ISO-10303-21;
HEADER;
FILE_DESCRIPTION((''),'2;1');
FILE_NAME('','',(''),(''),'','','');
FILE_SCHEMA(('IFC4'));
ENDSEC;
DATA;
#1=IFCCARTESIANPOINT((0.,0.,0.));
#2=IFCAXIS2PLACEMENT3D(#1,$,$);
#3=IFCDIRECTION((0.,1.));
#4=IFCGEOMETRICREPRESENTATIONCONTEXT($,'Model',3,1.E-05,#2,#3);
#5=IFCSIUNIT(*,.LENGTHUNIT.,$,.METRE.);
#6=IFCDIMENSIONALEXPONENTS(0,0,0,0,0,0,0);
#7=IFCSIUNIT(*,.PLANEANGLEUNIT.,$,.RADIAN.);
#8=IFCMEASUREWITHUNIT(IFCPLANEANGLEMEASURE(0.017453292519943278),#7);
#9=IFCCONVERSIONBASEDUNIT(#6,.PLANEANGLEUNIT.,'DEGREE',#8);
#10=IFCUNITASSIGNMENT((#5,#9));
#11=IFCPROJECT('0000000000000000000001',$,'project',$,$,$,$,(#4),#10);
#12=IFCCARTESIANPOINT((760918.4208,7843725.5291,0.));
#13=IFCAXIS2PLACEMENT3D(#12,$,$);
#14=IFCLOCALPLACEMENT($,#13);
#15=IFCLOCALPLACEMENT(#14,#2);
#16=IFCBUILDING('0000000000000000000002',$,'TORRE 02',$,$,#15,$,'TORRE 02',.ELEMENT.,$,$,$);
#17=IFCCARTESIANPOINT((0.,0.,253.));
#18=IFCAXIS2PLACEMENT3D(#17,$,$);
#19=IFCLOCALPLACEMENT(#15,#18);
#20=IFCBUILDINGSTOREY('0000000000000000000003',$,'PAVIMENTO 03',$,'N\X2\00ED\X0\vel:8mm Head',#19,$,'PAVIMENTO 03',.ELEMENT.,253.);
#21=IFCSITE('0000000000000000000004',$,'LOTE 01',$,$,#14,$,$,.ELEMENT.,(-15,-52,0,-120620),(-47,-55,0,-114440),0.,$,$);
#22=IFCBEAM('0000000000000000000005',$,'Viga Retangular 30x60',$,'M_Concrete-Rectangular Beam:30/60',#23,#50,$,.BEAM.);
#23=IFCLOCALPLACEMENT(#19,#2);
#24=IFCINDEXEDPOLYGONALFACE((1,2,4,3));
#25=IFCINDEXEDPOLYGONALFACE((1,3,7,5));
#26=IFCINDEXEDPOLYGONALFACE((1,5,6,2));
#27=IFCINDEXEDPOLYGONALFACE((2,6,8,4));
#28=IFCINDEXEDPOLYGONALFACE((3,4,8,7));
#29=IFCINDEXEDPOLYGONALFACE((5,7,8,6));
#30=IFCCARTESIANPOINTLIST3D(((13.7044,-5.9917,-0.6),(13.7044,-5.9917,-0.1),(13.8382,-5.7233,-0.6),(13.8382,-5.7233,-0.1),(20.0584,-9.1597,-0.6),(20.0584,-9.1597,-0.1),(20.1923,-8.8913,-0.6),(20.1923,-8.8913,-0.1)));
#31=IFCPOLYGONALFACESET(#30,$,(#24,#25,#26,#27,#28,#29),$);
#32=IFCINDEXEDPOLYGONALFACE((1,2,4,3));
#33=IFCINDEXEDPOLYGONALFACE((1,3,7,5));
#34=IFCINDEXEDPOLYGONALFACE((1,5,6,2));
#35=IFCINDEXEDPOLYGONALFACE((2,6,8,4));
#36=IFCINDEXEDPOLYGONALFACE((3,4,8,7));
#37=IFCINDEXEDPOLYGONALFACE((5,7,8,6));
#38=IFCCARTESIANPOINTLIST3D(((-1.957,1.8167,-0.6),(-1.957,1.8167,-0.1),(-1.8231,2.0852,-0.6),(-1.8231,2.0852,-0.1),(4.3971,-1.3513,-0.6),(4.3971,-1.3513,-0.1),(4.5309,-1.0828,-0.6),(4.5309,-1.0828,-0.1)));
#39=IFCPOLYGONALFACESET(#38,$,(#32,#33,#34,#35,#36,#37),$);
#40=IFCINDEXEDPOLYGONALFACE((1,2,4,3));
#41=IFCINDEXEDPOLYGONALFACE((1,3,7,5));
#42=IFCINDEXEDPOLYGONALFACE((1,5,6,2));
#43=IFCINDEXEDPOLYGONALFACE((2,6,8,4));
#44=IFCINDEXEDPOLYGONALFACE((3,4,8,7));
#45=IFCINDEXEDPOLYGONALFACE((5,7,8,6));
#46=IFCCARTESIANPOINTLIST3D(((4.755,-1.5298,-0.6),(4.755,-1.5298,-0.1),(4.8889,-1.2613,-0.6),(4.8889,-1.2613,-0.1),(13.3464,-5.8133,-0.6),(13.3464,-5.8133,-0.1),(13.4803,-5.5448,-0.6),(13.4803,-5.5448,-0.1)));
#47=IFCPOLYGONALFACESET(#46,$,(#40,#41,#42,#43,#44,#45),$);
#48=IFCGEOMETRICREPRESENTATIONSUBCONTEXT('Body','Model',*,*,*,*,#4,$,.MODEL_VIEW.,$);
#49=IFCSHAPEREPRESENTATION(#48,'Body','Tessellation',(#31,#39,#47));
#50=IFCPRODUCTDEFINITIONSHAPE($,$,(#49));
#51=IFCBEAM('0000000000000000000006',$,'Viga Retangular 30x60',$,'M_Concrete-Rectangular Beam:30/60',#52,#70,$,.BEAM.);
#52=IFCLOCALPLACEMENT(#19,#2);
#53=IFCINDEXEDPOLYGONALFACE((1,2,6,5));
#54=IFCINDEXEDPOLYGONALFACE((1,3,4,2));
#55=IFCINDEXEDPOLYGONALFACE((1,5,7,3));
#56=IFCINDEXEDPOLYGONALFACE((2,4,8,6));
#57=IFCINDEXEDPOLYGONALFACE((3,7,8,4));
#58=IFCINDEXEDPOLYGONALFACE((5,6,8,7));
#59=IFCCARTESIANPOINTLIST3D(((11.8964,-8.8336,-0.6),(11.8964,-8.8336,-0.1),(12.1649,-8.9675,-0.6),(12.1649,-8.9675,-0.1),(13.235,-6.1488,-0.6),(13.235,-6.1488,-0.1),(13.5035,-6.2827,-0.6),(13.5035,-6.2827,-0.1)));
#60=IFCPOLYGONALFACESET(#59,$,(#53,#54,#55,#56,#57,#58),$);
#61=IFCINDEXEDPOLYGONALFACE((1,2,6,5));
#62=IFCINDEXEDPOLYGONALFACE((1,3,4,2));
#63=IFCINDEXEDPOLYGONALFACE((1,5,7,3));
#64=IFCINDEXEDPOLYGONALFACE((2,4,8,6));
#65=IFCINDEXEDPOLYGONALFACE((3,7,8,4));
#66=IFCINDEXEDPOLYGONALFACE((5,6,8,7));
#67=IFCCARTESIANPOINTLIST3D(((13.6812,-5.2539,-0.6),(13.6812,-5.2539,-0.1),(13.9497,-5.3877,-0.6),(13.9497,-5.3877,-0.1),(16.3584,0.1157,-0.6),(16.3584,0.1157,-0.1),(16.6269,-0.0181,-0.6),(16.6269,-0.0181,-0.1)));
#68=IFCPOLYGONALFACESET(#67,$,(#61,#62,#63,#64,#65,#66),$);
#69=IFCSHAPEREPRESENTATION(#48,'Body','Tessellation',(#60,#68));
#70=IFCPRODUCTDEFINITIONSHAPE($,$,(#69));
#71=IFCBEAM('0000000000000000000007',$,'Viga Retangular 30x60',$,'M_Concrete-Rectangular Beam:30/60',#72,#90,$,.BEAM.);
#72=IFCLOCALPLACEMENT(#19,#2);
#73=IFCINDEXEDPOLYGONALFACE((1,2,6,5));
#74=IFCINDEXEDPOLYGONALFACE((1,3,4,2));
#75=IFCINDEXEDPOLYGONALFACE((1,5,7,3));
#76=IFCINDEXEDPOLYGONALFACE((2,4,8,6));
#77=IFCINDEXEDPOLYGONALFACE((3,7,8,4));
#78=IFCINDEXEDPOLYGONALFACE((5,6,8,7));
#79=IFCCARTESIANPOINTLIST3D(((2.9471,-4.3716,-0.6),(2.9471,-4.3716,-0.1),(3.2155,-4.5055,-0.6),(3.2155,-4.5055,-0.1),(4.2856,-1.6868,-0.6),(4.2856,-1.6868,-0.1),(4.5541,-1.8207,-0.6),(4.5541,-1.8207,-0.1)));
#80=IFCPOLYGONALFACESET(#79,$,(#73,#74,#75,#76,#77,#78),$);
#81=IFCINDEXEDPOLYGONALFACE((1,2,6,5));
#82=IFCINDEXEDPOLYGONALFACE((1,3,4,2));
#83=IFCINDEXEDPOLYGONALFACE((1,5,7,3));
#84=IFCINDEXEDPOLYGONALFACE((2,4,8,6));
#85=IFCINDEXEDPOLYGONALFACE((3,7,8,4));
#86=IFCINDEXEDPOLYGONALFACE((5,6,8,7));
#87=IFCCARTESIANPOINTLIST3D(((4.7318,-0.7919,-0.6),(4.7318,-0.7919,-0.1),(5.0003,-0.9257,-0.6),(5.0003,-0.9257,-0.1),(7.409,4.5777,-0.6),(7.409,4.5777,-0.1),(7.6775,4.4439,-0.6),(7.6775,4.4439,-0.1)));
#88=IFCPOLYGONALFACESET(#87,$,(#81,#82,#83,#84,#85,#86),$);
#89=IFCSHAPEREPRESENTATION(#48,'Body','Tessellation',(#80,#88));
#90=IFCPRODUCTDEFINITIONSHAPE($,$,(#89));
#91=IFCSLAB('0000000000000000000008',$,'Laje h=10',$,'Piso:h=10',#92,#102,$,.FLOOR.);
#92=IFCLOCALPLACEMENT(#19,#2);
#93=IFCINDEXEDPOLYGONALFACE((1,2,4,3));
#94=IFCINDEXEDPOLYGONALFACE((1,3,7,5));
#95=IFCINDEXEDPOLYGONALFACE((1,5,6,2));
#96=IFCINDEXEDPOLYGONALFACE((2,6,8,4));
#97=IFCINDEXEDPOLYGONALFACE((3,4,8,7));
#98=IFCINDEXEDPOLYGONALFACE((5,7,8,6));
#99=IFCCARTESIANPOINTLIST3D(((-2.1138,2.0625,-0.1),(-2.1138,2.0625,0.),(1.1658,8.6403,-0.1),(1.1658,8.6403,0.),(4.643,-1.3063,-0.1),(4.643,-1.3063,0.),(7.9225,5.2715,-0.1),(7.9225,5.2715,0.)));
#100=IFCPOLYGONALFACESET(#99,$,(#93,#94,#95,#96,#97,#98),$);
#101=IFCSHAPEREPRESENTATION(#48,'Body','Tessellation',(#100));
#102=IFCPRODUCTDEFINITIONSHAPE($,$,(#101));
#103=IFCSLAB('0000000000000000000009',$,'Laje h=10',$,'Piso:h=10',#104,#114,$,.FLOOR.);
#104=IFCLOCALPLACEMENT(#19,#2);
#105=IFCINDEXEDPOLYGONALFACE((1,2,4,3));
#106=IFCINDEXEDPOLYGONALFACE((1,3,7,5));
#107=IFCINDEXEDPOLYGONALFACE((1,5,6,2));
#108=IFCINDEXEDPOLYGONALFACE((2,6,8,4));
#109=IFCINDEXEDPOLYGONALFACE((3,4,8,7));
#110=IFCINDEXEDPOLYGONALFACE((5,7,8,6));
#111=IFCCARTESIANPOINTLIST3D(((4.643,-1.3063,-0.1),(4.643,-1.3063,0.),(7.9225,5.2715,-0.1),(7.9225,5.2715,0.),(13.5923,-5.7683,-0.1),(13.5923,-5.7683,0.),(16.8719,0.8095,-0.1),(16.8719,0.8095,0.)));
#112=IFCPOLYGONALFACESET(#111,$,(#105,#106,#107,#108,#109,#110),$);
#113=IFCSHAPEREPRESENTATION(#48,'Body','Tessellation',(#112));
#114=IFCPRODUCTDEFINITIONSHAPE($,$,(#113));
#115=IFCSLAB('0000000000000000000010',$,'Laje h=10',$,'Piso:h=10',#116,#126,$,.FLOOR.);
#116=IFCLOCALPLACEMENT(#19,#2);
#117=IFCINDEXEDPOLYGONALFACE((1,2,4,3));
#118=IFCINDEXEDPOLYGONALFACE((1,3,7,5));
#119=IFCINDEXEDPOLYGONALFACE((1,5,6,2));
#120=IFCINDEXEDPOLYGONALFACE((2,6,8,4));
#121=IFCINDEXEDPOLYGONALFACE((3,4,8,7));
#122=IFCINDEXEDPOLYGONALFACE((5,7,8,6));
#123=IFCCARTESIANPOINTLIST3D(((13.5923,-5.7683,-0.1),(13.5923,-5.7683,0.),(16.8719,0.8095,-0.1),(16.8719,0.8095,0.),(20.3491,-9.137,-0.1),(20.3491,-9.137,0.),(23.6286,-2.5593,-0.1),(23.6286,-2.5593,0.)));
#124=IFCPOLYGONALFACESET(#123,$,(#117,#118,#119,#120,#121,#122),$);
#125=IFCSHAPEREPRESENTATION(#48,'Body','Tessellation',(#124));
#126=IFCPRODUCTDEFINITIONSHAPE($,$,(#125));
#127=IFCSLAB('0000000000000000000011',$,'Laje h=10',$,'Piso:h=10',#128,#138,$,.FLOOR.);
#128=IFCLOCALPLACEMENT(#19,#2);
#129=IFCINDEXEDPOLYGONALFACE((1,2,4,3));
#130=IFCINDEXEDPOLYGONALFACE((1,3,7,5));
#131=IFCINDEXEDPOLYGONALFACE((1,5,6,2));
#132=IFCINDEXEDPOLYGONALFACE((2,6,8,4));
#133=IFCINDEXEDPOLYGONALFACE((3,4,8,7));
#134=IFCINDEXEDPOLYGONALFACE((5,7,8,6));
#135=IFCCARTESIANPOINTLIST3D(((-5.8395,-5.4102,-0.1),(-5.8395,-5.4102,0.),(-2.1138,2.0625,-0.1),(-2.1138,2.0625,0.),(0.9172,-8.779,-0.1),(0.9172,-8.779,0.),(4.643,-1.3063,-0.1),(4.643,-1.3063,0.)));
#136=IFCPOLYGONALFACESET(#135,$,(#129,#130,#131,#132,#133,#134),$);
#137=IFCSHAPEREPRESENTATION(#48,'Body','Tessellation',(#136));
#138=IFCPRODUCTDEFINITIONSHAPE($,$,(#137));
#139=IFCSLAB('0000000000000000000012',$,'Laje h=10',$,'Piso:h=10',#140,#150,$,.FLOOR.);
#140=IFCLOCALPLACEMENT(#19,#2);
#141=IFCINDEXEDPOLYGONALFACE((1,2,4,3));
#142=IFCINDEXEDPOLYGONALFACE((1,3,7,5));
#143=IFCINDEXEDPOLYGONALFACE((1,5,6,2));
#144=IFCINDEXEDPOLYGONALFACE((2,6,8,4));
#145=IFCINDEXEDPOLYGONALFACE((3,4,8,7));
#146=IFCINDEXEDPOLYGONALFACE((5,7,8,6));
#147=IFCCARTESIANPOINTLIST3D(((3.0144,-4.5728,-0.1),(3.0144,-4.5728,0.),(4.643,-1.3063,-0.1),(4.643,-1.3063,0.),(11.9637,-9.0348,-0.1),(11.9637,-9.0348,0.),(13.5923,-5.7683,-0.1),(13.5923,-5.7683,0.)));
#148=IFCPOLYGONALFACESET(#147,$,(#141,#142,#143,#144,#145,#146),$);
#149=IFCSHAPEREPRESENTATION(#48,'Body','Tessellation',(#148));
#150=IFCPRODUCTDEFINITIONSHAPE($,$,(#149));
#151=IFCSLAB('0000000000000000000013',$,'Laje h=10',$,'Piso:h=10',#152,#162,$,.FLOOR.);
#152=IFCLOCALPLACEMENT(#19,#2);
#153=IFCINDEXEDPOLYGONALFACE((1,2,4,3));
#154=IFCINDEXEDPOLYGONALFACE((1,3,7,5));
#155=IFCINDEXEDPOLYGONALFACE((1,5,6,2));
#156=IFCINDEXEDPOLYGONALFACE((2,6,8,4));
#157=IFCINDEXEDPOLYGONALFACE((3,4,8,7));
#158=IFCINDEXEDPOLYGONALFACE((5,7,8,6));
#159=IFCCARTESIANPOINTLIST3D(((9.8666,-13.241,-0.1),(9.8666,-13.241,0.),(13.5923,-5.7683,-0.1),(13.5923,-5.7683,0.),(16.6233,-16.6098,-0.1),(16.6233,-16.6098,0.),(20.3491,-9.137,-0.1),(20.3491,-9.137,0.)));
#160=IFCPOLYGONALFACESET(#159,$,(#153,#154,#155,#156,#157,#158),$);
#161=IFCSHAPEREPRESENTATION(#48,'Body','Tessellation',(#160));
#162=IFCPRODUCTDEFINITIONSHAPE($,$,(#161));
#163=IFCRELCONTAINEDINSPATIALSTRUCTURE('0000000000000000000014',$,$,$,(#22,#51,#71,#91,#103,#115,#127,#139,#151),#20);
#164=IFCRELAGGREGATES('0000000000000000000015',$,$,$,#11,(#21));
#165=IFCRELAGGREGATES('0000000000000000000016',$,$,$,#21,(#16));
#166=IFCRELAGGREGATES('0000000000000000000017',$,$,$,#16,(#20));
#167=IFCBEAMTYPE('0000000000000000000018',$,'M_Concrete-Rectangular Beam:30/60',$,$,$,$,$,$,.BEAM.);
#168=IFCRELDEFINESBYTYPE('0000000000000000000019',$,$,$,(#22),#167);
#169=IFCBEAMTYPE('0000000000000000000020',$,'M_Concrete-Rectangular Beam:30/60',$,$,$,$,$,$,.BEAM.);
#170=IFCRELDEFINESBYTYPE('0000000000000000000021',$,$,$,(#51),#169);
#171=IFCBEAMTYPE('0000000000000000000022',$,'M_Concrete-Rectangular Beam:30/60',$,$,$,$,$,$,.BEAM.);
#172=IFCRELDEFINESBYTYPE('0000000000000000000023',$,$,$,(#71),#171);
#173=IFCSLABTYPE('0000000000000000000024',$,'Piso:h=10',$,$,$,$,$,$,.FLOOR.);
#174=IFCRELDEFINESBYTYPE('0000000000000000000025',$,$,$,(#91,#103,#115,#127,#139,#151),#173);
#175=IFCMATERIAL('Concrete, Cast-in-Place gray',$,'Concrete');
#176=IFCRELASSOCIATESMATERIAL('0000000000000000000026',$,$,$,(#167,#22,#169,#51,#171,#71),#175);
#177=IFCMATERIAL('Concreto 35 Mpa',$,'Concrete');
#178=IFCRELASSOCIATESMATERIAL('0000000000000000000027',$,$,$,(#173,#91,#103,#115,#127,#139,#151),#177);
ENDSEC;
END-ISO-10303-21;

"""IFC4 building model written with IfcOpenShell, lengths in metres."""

from ifc_helpers import new_model, entity, si_unit, converted_unit, direction, frame, origin, place, context, subcontext, project, spatial, indexed_curve, outline, extrude, source, transform, mapped, material, type_object, type_shapes, element, save


model = new_model("IFC4")

# Units and contexts
model_context = context("Model", 3, precision=1e-05, world=origin(), true_north=direction((0.0, 1.0)))
body_context = subcontext(model_context, "Body", "Model", "MODEL_VIEW")
ifc_project = project(units=[si_unit("LENGTHUNIT", "METRE"), converted_unit("PLANEANGLEUNIT", "DEGREE", entity("IfcPlaneAngleMeasure", 0.017453292519943278), si_unit("PLANEANGLEUNIT", "RADIAN"), dimensions=[0, 0, 0, 0, 0, 0, 0])], contexts=[model_context])

# Site, building, storey
site_placement = place(None, frame((760918.4208, 7843725.5291, 0.0)))
site = spatial("IfcSite", under=ifc_project, at=site_placement, Name="LOTE 01", CompositionType="ELEMENT", RefLatitude=(-15, -52, 0, -120620), RefLongitude=(-47, -55, 0, -114440), RefElevation=0.0)
building_placement = place(site_placement, origin())
building = spatial("IfcBuilding", under=site, at=building_placement, Name="TORRE 02", LongName="TORRE 02", CompositionType="ELEMENT")
storey_placement = place(building_placement, frame((0.0, 0.0, 253.0)))
storey = spatial("IfcBuildingStorey", under=building, at=storey_placement, Name="PAVIMENTO 03", ObjectType="Nível:8mm Head", LongName="PAVIMENTO 03", CompositionType="ELEMENT", Elevation=253.0)

# Shared definitions
ifc_material_1 = material(Name="Concrete, Cast-in-Place gray", Category="Concrete")

# Beams
beam_type_1 = type_object("IfcBeamType", Name="M_Concrete-Rectangular Beam:30/60", PredefinedType="BEAM", material=ifc_material_1)
shared_shape_1 = source(origin(), body_context, "Body", "SweptSolid", [
    extrude(outline(indexed_curve([(-0.25, -0.15), (0.25, -0.15), (0.25, 0.15), (-0.25, 0.15), (-0.25, -0.15)], self_intersect=False)), frame((13.7713, -5.8575, 252.65), z_axis=(0.894934, -0.446198, 0.0), x_axis=(0.0, 0.0, -1.0)), (0.0, 0.0, 1.0), 7.1),
    extrude(outline(indexed_curve([(-0.25, -0.15), (0.25, -0.15), (0.25, 0.15), (-0.25, 0.15), (-0.25, -0.15)], self_intersect=False)), frame((-1.89, 1.951, 252.65), z_axis=(0.894934, -0.446198, 0.0), x_axis=(0.0, 0.0, -1.0)), (0.0, 0.0, 1.0), 7.1),
    extrude(outline(indexed_curve([(-0.25, -0.15), (0.25, -0.15), (0.25, 0.15), (-0.25, 0.15), (-0.25, -0.15)], self_intersect=False)), frame((4.822, -1.3955, 252.65), z_axis=(0.894934, -0.446198, 0.0), x_axis=(0.0, 0.0, -1.0)), (0.0, 0.0, 1.0), 9.6),
])
type_shapes(beam_type_1, [shared_shape_1])
beam_1_placement = place(storey_placement, frame((0.0, 0.0, -253.0)))
element("IfcBeam", 1, at=beam_1_placement, inside=storey, type_object=beam_type_1, material=ifc_material_1, Name="Viga Retangular 30x60", ObjectType="M_Concrete-Rectangular Beam:30/60", PredefinedType="BEAM", context=body_context, shape_type="MappedRepresentation", body=[
    mapped(shared_shape_1, transform((0.0, 0.0, 0.0), scale=1.0)),
])
beam_type_2 = type_object("IfcBeamType", Name="M_Concrete-Rectangular Beam:30/60", PredefinedType="BEAM", material=ifc_material_1)
shared_shape_2 = source(origin(), body_context, "Body", "SweptSolid", [
    extrude(outline(indexed_curve([(-0.25, -0.15), (0.25, -0.15), (0.25, 0.15), (-0.25, 0.15), (-0.25, -0.15)], self_intersect=False)), frame((12.0306, -8.9005, 252.65), z_axis=(0.446198, 0.894934, 0.0), x_axis=(0.0, 0.0, 1.0)), (0.0, 0.0, 1.0), 3.0),
    extrude(outline(indexed_curve([(-0.25, -0.15), (0.25, -0.15), (0.25, 0.15), (-0.25, 0.15), (-0.25, -0.15)], self_intersect=False)), frame((13.8154, -5.3208, 252.65), z_axis=(0.446198, 0.894934, 0.0), x_axis=(0.0, 0.0, 1.0)), (0.0, 0.0, 1.0), 6.0),
])
type_shapes(beam_type_2, [shared_shape_2])
beam_2_placement = place(storey_placement, frame((0.0, 0.0, -253.0)))
element("IfcBeam", 2, at=beam_2_placement, inside=storey, type_object=beam_type_2, material=ifc_material_1, Name="Viga Retangular 30x60", ObjectType="M_Concrete-Rectangular Beam:30/60", PredefinedType="BEAM", context=body_context, shape_type="MappedRepresentation", body=[
    mapped(shared_shape_2, transform((0.0, 0.0, 0.0), scale=1.0)),
])
beam_type_3 = type_object("IfcBeamType", Name="M_Concrete-Rectangular Beam:30/60", PredefinedType="BEAM", material=ifc_material_1)
shared_shape_3 = source(origin(), body_context, "Body", "SweptSolid", [
    extrude(outline(indexed_curve([(-0.25, -0.15), (0.25, -0.15), (0.25, 0.15), (-0.25, 0.15), (-0.25, -0.15)], self_intersect=False)), frame((3.0813, -4.4385, 252.65), z_axis=(0.446198, 0.894934, 0.0), x_axis=(0.0, 0.0, 1.0)), (0.0, 0.0, 1.0), 3.0),
    extrude(outline(indexed_curve([(-0.25, -0.15), (0.25, -0.15), (0.25, 0.15), (-0.25, 0.15), (-0.25, -0.15)], self_intersect=False)), frame((4.8661, -0.8588, 252.65), z_axis=(0.446198, 0.894934, 0.0), x_axis=(0.0, 0.0, 1.0)), (0.0, 0.0, 1.0), 6.0),
])
type_shapes(beam_type_3, [shared_shape_3])
beam_3_placement = place(storey_placement, frame((0.0, 0.0, -253.0)))
element("IfcBeam", 3, at=beam_3_placement, inside=storey, type_object=beam_type_3, material=ifc_material_1, Name="Viga Retangular 30x60", ObjectType="M_Concrete-Rectangular Beam:30/60", PredefinedType="BEAM", context=body_context, shape_type="MappedRepresentation", body=[
    mapped(shared_shape_3, transform((0.0, 0.0, 0.0), scale=1.0)),
])

# Slabs
ifc_material_2 = material(Name="Concreto 35 Mpa", Category="Concrete")
slab_type = type_object("IfcSlabType", Name="Piso:h=10", PredefinedType="FLOOR", material=ifc_material_2)
slab_1_placement = place(storey_placement, origin())
element("IfcSlab", 4, at=slab_1_placement, inside=storey, type_object=slab_type, material=ifc_material_2, Name="Laje h=10", ObjectType="Piso:h=10", PredefinedType="FLOOR", context=body_context, shape_type="SweptSolid", body=[
    extrude(outline(indexed_curve([(-3.675, -3.775), (3.675, -3.775), (3.675, 3.775), (-3.675, 3.775), (-3.675, -3.775)], self_intersect=False)), frame((2.9044, 3.667, 0.0), z_axis=(0.0, 0.0, -1.0), x_axis=(-0.446198, -0.894934, 0.0)), (0.0, 0.0, 1.0), 0.1),
])
slab_2_placement = place(storey_placement, origin())
element("IfcSlab", 5, at=slab_2_placement, inside=storey, type_object=slab_type, material=ifc_material_2, Name="Laje h=10", ObjectType="Piso:h=10", PredefinedType="FLOOR", context=body_context, shape_type="SweptSolid", body=[
    extrude(outline(indexed_curve([(-3.675, -5.0), (3.675, -5.0), (3.675, 5.0), (-3.675, 5.0), (-3.675, -5.0)], self_intersect=False)), frame((10.7574, -0.2484, 0.0), z_axis=(0.0, 0.0, -1.0), x_axis=(-0.446198, -0.894934, 0.0)), (0.0, 0.0, 1.0), 0.1),
])
slab_3_placement = place(storey_placement, origin())
element("IfcSlab", 6, at=slab_3_placement, inside=storey, type_object=slab_type, material=ifc_material_2, Name="Laje h=10", ObjectType="Piso:h=10", PredefinedType="FLOOR", context=body_context, shape_type="SweptSolid", body=[
    extrude(outline(indexed_curve([(-3.675, -3.775), (3.675, -3.775), (3.675, 3.775), (-3.675, 3.775), (-3.675, -3.775)], self_intersect=False)), frame((18.6105, -4.1638, 0.0), z_axis=(0.0, 0.0, -1.0), x_axis=(-0.446198, -0.894934, 0.0)), (0.0, 0.0, 1.0), 0.1),
])
slab_4_placement = place(storey_placement, origin())
element("IfcSlab", 7, at=slab_4_placement, inside=storey, type_object=slab_type, material=ifc_material_2, Name="Laje h=10", ObjectType="Piso:h=10", PredefinedType="FLOOR", context=body_context, shape_type="SweptSolid", body=[
    extrude(outline(indexed_curve([(-4.175, -3.775), (4.175, -3.775), (4.175, 3.775), (-4.175, 3.775), (-4.175, -3.775)], self_intersect=False)), frame((-0.5983, -3.3582, 0.0), z_axis=(0.0, 0.0, -1.0), x_axis=(-0.446198, -0.894934, 0.0)), (0.0, 0.0, 1.0), 0.1),
])
slab_5_placement = place(storey_placement, origin())
element("IfcSlab", 8, at=slab_5_placement, inside=storey, type_object=slab_type, material=ifc_material_2, Name="Laje h=10", ObjectType="Piso:h=10", PredefinedType="FLOOR", context=body_context, shape_type="SweptSolid", body=[
    extrude(outline(indexed_curve([(-1.825, -5.0), (1.825, -5.0), (1.825, 5.0), (-1.825, 5.0), (-1.825, -5.0)], self_intersect=False)), frame((8.3033, -5.1705, 0.0), z_axis=(0.0, 0.0, -1.0), x_axis=(-0.446198, -0.894934, 0.0)), (0.0, 0.0, 1.0), 0.1),
])
slab_6_placement = place(storey_placement, origin())
element("IfcSlab", 9, at=slab_6_placement, inside=storey, type_object=slab_type, material=ifc_material_2, Name="Laje h=10", ObjectType="Piso:h=10", PredefinedType="FLOOR", context=body_context, shape_type="SweptSolid", body=[
    extrude(outline(indexed_curve([(-4.175, -3.775), (4.175, -3.775), (4.175, 3.775), (-4.175, 3.775), (-4.175, -3.775)], self_intersect=False)), frame((15.1078, -11.189, 0.0), z_axis=(0.0, 0.0, -1.0), x_axis=(-0.446198, -0.894934, 0.0)), (0.0, 0.0, 1.0), 0.1),
])

save(model, "model.ifc")
